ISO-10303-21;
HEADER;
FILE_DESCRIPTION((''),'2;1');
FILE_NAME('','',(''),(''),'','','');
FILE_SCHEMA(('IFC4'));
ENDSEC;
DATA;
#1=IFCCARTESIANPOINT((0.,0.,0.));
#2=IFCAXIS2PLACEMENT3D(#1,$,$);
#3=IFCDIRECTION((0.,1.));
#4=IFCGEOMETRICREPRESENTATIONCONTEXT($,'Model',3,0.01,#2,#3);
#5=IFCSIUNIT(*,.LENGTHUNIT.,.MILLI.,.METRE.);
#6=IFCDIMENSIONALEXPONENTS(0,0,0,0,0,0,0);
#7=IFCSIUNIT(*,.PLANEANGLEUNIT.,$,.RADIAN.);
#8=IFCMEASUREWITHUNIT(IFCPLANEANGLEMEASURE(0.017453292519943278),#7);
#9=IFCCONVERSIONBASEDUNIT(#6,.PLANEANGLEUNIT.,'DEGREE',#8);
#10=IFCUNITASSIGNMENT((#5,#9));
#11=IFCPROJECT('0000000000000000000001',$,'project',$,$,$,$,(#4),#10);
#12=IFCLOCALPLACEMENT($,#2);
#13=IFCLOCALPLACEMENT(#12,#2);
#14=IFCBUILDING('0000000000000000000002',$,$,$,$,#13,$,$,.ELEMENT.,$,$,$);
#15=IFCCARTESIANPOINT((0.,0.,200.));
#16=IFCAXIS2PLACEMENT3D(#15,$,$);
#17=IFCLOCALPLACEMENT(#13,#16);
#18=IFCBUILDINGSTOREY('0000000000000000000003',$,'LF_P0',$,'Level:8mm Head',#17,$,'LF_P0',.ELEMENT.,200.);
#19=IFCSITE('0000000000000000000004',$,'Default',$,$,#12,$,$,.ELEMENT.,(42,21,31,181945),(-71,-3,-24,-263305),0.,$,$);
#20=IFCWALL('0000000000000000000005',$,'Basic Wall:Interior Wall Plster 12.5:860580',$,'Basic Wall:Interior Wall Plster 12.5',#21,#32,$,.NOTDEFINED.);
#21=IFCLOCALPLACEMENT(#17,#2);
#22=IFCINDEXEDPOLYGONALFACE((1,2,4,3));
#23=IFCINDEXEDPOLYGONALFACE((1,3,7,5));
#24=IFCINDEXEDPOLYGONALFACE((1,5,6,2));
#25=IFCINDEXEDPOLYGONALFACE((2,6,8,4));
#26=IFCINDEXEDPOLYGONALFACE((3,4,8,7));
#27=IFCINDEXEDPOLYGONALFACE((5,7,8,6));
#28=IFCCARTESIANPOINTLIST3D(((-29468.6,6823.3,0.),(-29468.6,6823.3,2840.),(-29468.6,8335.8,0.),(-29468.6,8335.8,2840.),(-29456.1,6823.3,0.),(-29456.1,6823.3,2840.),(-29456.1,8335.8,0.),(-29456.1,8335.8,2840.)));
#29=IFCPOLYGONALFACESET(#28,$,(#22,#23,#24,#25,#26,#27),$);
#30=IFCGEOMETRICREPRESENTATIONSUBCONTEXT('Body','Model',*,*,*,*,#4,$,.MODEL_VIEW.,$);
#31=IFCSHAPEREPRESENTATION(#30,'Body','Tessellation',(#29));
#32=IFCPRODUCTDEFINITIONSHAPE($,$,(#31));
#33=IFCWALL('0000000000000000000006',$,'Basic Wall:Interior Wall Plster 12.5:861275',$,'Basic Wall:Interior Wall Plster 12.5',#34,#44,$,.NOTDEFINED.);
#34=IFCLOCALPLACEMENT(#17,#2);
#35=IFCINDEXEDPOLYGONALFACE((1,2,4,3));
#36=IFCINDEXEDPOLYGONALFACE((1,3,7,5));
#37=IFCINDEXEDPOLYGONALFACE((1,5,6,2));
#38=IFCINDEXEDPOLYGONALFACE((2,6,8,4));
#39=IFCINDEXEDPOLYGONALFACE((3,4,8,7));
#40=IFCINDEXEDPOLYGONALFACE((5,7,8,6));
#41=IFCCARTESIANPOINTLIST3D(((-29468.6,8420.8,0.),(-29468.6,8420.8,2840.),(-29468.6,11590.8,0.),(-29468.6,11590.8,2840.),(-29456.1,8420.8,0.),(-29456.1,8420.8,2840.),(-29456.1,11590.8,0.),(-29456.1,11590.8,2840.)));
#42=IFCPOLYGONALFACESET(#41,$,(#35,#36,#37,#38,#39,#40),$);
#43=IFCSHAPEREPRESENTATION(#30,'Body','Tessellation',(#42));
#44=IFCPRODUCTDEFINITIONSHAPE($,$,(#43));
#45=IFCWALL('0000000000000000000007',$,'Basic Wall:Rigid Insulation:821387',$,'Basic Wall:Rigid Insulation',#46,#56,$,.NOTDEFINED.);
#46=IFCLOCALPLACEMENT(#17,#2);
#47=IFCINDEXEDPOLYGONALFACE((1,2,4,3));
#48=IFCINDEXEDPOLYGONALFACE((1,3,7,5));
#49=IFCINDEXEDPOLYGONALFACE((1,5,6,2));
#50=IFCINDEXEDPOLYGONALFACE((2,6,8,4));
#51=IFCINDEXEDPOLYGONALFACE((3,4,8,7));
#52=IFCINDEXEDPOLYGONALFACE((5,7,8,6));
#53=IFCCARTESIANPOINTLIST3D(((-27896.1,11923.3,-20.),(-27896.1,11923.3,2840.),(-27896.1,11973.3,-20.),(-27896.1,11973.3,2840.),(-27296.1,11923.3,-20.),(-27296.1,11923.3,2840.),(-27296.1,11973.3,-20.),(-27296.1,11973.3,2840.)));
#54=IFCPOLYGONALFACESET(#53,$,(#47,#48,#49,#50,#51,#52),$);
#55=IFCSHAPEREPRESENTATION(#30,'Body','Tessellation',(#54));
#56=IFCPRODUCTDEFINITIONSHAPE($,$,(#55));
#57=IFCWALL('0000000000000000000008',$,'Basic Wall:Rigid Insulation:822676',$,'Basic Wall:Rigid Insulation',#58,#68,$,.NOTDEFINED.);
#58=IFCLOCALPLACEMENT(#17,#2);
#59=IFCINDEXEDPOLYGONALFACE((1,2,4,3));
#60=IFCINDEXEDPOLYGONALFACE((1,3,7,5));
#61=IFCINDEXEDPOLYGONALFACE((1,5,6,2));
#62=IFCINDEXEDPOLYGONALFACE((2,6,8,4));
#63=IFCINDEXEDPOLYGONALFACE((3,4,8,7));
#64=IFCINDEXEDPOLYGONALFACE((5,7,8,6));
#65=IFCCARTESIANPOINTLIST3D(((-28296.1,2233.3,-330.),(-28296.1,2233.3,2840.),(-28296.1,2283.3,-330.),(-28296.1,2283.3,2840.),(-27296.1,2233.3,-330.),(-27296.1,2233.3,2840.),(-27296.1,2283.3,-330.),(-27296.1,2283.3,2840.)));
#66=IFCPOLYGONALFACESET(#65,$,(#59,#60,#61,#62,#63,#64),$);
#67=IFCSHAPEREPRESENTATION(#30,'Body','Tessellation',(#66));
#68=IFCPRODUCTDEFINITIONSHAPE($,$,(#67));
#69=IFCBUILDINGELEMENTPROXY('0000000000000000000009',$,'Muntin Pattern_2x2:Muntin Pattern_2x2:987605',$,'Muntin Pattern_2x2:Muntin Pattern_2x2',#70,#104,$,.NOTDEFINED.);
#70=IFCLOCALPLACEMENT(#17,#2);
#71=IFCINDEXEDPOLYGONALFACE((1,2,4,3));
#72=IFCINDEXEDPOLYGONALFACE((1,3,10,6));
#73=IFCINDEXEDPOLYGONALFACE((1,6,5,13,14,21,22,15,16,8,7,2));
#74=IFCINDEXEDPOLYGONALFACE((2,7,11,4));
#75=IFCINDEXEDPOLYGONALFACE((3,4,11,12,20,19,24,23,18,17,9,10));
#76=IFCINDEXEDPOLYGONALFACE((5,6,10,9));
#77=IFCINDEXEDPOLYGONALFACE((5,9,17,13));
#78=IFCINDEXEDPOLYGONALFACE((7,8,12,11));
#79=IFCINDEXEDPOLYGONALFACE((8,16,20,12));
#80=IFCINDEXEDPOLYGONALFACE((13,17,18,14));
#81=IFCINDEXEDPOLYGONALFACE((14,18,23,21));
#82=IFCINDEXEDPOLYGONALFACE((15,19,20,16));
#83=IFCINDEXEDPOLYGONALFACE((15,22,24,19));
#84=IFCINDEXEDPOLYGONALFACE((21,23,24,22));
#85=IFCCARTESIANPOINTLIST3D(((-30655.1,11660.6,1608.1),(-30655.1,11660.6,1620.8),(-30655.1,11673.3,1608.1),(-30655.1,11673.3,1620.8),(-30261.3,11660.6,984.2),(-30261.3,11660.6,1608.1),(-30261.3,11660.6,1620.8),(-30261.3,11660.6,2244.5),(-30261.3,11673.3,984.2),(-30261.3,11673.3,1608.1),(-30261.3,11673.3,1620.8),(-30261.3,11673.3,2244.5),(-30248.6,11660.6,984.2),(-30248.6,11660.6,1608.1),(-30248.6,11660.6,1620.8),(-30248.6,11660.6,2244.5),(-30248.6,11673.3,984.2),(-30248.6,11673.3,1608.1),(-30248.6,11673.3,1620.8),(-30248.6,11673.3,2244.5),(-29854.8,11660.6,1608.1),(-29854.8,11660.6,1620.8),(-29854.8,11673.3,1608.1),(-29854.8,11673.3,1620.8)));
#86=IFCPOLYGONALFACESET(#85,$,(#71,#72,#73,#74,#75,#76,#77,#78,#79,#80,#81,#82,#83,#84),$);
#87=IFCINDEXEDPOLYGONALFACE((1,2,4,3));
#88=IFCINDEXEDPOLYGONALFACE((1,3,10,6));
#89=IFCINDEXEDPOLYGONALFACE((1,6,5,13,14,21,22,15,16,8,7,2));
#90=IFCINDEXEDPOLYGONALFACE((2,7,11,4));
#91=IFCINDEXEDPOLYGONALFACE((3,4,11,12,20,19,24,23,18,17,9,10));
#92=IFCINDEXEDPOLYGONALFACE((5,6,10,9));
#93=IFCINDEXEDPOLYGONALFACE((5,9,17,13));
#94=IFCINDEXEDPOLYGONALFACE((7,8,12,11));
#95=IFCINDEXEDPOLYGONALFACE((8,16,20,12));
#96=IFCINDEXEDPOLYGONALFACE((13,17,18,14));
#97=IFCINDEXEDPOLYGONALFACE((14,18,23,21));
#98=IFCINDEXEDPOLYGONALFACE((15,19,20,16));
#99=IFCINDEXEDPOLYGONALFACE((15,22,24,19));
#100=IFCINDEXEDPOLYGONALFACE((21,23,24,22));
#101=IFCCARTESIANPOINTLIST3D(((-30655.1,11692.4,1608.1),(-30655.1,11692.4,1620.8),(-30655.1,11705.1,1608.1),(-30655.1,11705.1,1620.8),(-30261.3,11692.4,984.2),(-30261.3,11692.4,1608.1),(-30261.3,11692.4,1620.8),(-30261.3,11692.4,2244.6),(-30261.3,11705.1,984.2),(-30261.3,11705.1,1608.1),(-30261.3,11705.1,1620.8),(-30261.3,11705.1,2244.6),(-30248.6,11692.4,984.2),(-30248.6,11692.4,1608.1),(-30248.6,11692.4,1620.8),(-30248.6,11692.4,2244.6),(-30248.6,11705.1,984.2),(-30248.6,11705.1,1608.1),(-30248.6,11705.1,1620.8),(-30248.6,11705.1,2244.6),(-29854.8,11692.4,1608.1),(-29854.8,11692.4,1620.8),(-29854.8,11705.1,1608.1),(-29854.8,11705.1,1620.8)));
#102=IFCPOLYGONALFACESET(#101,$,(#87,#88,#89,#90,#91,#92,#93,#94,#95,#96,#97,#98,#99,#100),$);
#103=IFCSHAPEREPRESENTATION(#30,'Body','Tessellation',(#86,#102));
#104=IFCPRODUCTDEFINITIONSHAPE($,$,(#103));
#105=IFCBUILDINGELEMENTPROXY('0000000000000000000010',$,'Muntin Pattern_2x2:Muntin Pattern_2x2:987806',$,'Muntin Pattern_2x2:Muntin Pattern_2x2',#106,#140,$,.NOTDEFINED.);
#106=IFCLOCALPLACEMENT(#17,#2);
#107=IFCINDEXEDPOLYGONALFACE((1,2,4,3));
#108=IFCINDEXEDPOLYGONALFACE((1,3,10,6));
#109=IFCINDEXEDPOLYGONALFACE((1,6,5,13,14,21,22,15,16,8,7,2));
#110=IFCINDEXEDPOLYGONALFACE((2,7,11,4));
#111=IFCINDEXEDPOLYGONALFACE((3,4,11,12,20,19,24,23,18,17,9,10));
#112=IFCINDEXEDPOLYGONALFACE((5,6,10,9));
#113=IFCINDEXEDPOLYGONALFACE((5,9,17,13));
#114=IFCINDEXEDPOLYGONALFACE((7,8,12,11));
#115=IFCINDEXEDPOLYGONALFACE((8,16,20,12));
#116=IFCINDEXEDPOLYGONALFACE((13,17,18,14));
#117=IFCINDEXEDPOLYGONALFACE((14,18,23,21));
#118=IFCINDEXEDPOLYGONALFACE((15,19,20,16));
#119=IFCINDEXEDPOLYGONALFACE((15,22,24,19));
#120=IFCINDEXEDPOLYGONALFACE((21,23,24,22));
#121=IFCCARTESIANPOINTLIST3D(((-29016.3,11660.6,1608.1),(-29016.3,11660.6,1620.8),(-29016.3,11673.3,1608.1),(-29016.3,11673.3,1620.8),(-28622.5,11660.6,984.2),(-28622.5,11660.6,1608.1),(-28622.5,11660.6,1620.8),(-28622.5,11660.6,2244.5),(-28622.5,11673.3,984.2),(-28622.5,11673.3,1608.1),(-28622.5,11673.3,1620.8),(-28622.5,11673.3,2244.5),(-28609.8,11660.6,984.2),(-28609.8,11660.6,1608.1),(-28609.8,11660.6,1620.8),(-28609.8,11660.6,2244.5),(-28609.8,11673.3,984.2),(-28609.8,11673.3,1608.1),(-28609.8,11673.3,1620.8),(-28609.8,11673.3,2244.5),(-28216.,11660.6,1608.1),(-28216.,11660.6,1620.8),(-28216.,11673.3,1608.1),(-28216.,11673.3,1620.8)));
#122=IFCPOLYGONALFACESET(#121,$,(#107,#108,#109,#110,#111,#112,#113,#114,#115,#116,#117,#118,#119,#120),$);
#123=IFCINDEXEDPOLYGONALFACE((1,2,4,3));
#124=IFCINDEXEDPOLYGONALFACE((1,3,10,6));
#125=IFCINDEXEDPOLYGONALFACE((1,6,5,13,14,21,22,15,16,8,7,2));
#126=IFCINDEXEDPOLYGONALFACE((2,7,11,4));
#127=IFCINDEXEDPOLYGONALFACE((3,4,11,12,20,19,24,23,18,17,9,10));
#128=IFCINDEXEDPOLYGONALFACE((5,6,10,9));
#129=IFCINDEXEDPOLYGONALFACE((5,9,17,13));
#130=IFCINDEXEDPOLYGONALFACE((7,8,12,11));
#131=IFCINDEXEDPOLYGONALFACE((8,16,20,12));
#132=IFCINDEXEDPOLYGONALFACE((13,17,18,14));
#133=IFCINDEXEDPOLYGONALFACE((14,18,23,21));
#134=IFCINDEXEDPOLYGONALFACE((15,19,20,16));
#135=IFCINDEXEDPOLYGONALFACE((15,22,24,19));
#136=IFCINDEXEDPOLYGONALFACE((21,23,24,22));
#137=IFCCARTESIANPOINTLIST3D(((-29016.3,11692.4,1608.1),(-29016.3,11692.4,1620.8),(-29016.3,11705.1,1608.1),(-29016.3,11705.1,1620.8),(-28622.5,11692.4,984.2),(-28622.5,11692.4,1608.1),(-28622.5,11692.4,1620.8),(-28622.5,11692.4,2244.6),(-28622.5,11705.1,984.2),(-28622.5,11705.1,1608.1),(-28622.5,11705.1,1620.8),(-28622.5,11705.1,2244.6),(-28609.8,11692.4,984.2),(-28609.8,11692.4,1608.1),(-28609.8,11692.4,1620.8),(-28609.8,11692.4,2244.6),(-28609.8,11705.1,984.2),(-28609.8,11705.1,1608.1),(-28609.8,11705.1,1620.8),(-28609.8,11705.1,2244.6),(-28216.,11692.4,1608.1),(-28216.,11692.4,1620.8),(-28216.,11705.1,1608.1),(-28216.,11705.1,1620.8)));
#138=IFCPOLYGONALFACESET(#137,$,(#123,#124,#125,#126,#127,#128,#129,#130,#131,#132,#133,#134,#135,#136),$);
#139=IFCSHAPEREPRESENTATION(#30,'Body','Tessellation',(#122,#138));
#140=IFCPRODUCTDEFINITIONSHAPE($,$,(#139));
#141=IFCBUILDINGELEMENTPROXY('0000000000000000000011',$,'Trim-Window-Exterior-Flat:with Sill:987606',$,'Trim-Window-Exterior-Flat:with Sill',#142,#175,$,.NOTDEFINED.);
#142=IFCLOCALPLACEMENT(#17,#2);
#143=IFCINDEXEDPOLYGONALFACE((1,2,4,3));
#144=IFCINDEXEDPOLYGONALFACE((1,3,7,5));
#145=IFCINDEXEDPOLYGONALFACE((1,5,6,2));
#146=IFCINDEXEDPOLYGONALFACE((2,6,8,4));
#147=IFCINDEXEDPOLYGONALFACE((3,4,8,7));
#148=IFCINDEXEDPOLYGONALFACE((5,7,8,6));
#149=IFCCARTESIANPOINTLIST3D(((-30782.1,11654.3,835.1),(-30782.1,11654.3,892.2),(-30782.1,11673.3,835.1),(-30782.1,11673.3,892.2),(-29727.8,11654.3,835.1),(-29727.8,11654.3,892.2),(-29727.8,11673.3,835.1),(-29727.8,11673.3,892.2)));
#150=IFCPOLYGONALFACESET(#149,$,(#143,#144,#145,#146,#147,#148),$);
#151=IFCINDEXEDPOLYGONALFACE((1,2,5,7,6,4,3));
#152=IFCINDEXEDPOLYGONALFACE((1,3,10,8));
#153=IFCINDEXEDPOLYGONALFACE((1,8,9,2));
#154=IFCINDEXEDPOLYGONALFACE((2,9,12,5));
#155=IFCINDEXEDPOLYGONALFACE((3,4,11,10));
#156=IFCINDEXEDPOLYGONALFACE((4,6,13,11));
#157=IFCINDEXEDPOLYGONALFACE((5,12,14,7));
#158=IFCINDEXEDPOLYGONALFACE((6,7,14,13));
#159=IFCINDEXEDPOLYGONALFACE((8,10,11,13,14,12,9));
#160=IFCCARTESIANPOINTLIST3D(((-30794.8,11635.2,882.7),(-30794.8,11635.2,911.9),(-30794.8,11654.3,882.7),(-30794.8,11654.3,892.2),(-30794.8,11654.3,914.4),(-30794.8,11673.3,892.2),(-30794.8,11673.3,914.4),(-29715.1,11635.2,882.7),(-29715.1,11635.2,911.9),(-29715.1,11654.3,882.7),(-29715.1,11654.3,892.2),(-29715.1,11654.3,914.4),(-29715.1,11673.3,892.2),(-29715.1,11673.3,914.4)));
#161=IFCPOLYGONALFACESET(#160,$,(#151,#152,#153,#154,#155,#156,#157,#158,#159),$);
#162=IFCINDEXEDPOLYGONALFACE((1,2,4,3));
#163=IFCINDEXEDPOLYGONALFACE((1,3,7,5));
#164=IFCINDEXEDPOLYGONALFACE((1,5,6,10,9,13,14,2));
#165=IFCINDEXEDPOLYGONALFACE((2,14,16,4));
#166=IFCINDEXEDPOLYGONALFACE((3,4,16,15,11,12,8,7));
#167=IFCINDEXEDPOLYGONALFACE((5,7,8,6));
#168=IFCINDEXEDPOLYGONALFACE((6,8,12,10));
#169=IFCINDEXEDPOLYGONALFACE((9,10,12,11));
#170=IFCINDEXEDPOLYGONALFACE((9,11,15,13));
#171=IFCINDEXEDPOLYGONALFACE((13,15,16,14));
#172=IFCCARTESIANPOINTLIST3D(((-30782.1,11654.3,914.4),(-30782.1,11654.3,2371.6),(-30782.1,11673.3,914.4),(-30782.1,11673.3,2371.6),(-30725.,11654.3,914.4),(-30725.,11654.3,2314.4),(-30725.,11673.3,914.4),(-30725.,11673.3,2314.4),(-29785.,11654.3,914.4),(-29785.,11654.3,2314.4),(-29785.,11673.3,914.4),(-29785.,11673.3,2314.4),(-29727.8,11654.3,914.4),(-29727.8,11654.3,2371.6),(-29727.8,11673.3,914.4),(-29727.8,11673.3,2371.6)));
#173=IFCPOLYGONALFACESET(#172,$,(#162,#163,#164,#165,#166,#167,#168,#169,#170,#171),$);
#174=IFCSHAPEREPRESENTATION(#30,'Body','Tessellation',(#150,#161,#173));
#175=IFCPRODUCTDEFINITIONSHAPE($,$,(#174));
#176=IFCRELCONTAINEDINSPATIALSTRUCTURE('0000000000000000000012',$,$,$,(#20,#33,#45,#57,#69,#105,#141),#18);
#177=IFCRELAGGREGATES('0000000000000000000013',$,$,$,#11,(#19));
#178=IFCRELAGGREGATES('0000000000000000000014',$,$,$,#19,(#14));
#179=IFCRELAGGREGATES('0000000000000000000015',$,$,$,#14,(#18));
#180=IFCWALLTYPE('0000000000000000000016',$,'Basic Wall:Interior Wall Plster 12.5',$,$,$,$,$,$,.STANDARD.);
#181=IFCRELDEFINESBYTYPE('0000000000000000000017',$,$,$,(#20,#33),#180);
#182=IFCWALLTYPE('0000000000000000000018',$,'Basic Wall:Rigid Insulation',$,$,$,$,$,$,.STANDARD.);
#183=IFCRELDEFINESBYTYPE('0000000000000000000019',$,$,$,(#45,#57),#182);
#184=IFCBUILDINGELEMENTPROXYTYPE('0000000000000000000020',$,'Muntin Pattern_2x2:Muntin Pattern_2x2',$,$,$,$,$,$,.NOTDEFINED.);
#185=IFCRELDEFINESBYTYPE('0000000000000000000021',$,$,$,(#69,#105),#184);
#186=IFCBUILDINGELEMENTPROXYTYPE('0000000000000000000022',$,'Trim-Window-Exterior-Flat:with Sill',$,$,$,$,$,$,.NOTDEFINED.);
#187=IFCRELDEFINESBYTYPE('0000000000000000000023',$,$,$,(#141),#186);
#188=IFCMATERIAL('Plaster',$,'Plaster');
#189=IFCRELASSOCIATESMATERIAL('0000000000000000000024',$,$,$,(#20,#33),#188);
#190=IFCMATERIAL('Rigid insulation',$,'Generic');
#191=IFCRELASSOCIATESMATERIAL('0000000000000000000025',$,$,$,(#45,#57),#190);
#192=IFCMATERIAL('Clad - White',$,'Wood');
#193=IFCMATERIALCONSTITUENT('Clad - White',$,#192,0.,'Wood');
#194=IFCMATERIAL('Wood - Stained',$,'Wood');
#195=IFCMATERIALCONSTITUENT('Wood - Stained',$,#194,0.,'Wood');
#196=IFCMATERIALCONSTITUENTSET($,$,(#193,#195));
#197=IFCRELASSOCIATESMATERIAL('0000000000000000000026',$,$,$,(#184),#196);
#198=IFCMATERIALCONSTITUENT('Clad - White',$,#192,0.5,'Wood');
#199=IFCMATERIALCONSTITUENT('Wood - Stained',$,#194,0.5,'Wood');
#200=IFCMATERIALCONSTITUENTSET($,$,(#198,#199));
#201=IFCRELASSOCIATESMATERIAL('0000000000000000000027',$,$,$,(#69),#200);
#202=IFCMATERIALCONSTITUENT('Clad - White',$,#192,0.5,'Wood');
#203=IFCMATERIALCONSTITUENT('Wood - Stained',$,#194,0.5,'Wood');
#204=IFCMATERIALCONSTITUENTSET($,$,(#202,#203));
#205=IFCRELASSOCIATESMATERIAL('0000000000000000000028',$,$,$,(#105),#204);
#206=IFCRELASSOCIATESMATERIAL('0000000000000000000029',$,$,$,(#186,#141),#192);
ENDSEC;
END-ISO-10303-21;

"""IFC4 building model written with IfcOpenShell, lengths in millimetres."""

from ifc_helpers import new_model, entity, si_unit, converted_unit, direction, frame, origin, place, context, subcontext, project, spatial, indexed_curve, outline, extrude, source, transform, mapped, material, constituent, constituent_set, type_object, type_shapes, element, save


model = new_model("IFC4")

# Units and contexts
model_context = context("Model", 3, precision=0.01, world=origin(), true_north=direction((0.0, 1.0)))
body_context = subcontext(model_context, "Body", "Model", "MODEL_VIEW")
ifc_project = project(units=[si_unit("LENGTHUNIT", "METRE", prefix="MILLI"), converted_unit("PLANEANGLEUNIT", "DEGREE", entity("IfcPlaneAngleMeasure", 0.017453292519943278), si_unit("PLANEANGLEUNIT", "RADIAN"), dimensions=[0, 0, 0, 0, 0, 0, 0])], contexts=[model_context])

# Site, building, storey
site_placement = place(None, origin())
site = spatial("IfcSite", under=ifc_project, at=site_placement, Name="Default", CompositionType="ELEMENT", RefLatitude=(42, 21, 31, 181945), RefLongitude=(-71, -3, -24, -263305), RefElevation=0.0)
building_placement = place(site_placement, origin())
building = spatial("IfcBuilding", under=site, at=building_placement, CompositionType="ELEMENT")
storey_placement = place(building_placement, frame((0.0, 0.0, 200.0)))
storey = spatial("IfcBuildingStorey", under=building, at=storey_placement, Name="LF_P0", ObjectType="Level:8mm Head", LongName="LF_P0", CompositionType="ELEMENT", Elevation=200.0)

# Walls
ifc_material_1 = material(Name="Plaster", Category="Plaster")
wall_type_1 = type_object("IfcWallType", Name="Basic Wall:Interior Wall Plster 12.5", PredefinedType="STANDARD")
wall_1_placement = place(storey_placement, frame((-29462.4, 6823.3, 0.0), z_axis=(0.0, 0.0, 1.0), x_axis=(0.0, 1.0, 0.0)))
element("IfcWall", 1, at=wall_1_placement, inside=storey, type_object=wall_type_1, material=ifc_material_1, Name="Basic Wall:Interior Wall Plster 12.5:860580", ObjectType="Basic Wall:Interior Wall Plster 12.5", PredefinedType="NOTDEFINED", context=body_context, shape_type="SweptSolid", body=[
    extrude(outline(indexed_curve([(1512.5, 6.2), (0.0, 6.2), (0.0, -6.2), (1512.5, -6.2), (1512.5, 6.2)], self_intersect=False)), origin(), (0.0, 0.0, 1.0), 2840.0),
])
wall_2_placement = place(storey_placement, frame((-29462.4, 8420.8, 0.0), z_axis=(0.0, 0.0, 1.0), x_axis=(0.0, 1.0, 0.0)))
element("IfcWall", 2, at=wall_2_placement, inside=storey, type_object=wall_type_1, material=ifc_material_1, Name="Basic Wall:Interior Wall Plster 12.5:861275", ObjectType="Basic Wall:Interior Wall Plster 12.5", PredefinedType="NOTDEFINED", context=body_context, shape_type="SweptSolid", body=[
    extrude(outline(indexed_curve([(3170.0, 6.2), (0.0, 6.2), (0.0, -6.2), (3170.0, -6.2), (3170.0, 6.2)], self_intersect=False)), origin(), (0.0, 0.0, 1.0), 2840.0),
])
ifc_material_2 = material(Name="Rigid insulation", Category="Generic")
wall_type_2 = type_object("IfcWallType", Name="Basic Wall:Rigid Insulation", PredefinedType="STANDARD")
wall_3_placement = place(storey_placement, frame((-27896.1, 11948.3, -20.0)))
element("IfcWall", 3, at=wall_3_placement, inside=storey, type_object=wall_type_2, material=ifc_material_2, Name="Basic Wall:Rigid Insulation:821387", ObjectType="Basic Wall:Rigid Insulation", PredefinedType="NOTDEFINED", context=body_context, shape_type="SweptSolid", body=[
    extrude(outline(indexed_curve([(600.0, 25.0), (0.0, 25.0), (0.0, -25.0), (600.0, -25.0), (600.0, 25.0)], self_intersect=False)), origin(), (0.0, 0.0, 1.0), 2860.0),
])
wall_4_placement = place(storey_placement, frame((-27296.1, 2258.3, -330.0), z_axis=(0.0, 0.0, 1.0), x_axis=(-1.0, 0.0, 0.0)))
element("IfcWall", 4, at=wall_4_placement, inside=storey, type_object=wall_type_2, material=ifc_material_2, Name="Basic Wall:Rigid Insulation:822676", ObjectType="Basic Wall:Rigid Insulation", PredefinedType="NOTDEFINED", context=body_context, shape_type="SweptSolid", body=[
    extrude(outline(indexed_curve([(1000.0, 25.0), (0.0, 25.0), (0.0, -25.0), (1000.0, -25.0), (1000.0, 25.0)], self_intersect=False)), origin(), (0.0, 0.0, 1.0), 3170.0),
])

# Building element proxies
ifc_material_3 = material(Name="Clad - White", Category="Wood")
ifc_constituent_1 = constituent(ifc_material_3, Name="Clad - White", Category="Wood", fraction=0.5)
ifc_material_4 = material(Name="Wood - Stained", Category="Wood")
ifc_constituent_2 = constituent(ifc_material_4, Name="Wood - Stained", Category="Wood", fraction=0.5)
ifc_constituent_set_1 = constituent_set(constituents=[ifc_constituent_1, ifc_constituent_2])
ifc_constituent_3 = constituent(ifc_material_3, Name="Clad - White", Category="Wood", fraction=0.0)
ifc_constituent_4 = constituent(ifc_material_4, Name="Wood - Stained", Category="Wood", fraction=0.0)
ifc_constituent_set_2 = constituent_set(constituents=[ifc_constituent_3, ifc_constituent_4])
building_element_proxy_type_1 = type_object("IfcBuildingElementProxyType", Name="Muntin Pattern_2x2:Muntin Pattern_2x2", PredefinedType="NOTDEFINED", material=ifc_constituent_set_2)
shared_shape_1 = source(origin(), body_context, "Body", "SweptSolid", [
    extrude(outline(indexed_curve([(6.4, -6.4), (630.1, -6.4), (630.1, 6.3), (6.4, 6.3), (6.4, 400.2), (-6.3, 400.2), (-6.3, 6.3), (-630.2, 6.3), (-630.2, -6.4), (-6.3, -6.4), (-6.3, -400.1), (6.4, -400.1), (6.4, -6.4)], self_intersect=False)), frame((0.0, 9.5, 630.1), z_axis=(0.0, 1.0, 0.0), x_axis=(0.0, 0.0, 1.0)), (0.0, 0.0, 1.0), 12.7),
    extrude(outline(indexed_curve([(6.4, -6.4), (630.2, -6.4), (630.2, 6.3), (6.4, 6.3), (6.4, 400.2), (-6.3, 400.2), (-6.3, 6.3), (-630.2, 6.3), (-630.2, -6.4), (-6.3, -6.4), (-6.3, -400.1), (6.4, -400.1), (6.4, -6.4)], self_intersect=False)), frame((0.0, -22.2, 630.2), z_axis=(0.0, 1.0, 0.0), x_axis=(0.0, 0.0, 1.0)), (0.0, 0.0, 1.0), 12.7),
])
type_shapes(building_element_proxy_type_1, [shared_shape_1])
proxy_1_placement = place(storey_placement, frame((-30255.0, 11682.9, 984.3), z_axis=(0.0, 0.0, 1.0), x_axis=(-1.0, 0.0, 0.0)))
element("IfcBuildingElementProxy", 5, at=proxy_1_placement, inside=storey, type_object=building_element_proxy_type_1, material=ifc_constituent_set_1, Name="Muntin Pattern_2x2:Muntin Pattern_2x2:987605", ObjectType="Muntin Pattern_2x2:Muntin Pattern_2x2", PredefinedType="NOTDEFINED", context=body_context, shape_type="MappedRepresentation", body=[
    mapped(shared_shape_1, transform((0.0, 0.0, 0.0), scale=1.0)),
])
ifc_constituent_5 = constituent(ifc_material_3, Name="Clad - White", Category="Wood", fraction=0.5)
ifc_constituent_6 = constituent(ifc_material_4, Name="Wood - Stained", Category="Wood", fraction=0.5)
ifc_constituent_set_3 = constituent_set(constituents=[ifc_constituent_5, ifc_constituent_6])
proxy_2_placement = place(storey_placement, frame((-28616.1, 11682.9, 984.3), z_axis=(0.0, 0.0, 1.0), x_axis=(-1.0, 0.0, 0.0)))
element("IfcBuildingElementProxy", 6, at=proxy_2_placement, inside=storey, type_object=building_element_proxy_type_1, material=ifc_constituent_set_3, Name="Muntin Pattern_2x2:Muntin Pattern_2x2:987806", ObjectType="Muntin Pattern_2x2:Muntin Pattern_2x2", PredefinedType="NOTDEFINED", context=body_context, shape_type="MappedRepresentation", body=[
    mapped(shared_shape_1, transform((0.0, 0.0, 0.0), scale=1.0)),
])
building_element_proxy_type_2 = type_object("IfcBuildingElementProxyType", Name="Trim-Window-Exterior-Flat:with Sill", PredefinedType="NOTDEFINED", material=ifc_material_3)
shared_shape_2 = source(origin(), body_context, "Body", "SweptSolid", [
    extrude(outline(indexed_curve([(-527.1, -28.6), (527.1, -28.6), (527.1, 28.6), (-527.1, 28.6), (-527.1, -28.6)], self_intersect=False)), frame((0.0, -1450.8, 0.0), z_axis=(0.0, 0.0, 1.0), x_axis=(-1.0, 0.0, 0.0)), (0.0, 0.0, 1.0), 19.0),
    extrude(outline(indexed_curve([(-19.0, -16.0), (0.0, -16.0), (0.0, -6.4), (19.0, -6.4), (19.0, 15.8), (0.0, 15.8), (-19.0, 13.3), (-19.0, -16.0)], self_intersect=False)), frame((-539.8, -1415.8, 19.0), z_axis=(1.0, 0.0, 0.0), x_axis=(0.0, 0.0, -1.0)), (0.0, 0.0, 1.0), 1079.7),
    extrude(outline(indexed_curve([(-742.9, -527.1), (714.3, -527.1), (714.3, -470.0), (-685.7, -470.0), (-685.7, 470.0), (714.3, 470.0), (714.3, 527.1), (-742.9, 527.1), (-742.9, -527.1)], self_intersect=False)), frame((0.0, -685.7, 0.0), z_axis=(0.0, 0.0, 1.0), x_axis=(0.0, -1.0, 0.0)), (0.0, 0.0, 1.0), 19.0),
])
type_shapes(building_element_proxy_type_2, [shared_shape_2])
for number, where, z_axis, x_axis, name in (
    (7, (-30255.0, 11673.3, 2314.4), (0.0, -1.0, 0.0), (1.0, 0.0, 0.0), "Trim-Window-Exterior-Flat:with Sill:987606"),
):
    element("IfcBuildingElementProxy", number, at=place(storey_placement, frame(where, z_axis=z_axis, x_axis=x_axis)), inside=storey, type_object=building_element_proxy_type_2, material=ifc_material_3, Name=name, ObjectType="Trim-Window-Exterior-Flat:with Sill", PredefinedType="NOTDEFINED", context=body_context, shape_type="MappedRepresentation", body=[
        mapped(shared_shape_2, transform((0.0, 0.0, 0.0), scale=1.0)),
    ])

save(model, "model.ifc")
